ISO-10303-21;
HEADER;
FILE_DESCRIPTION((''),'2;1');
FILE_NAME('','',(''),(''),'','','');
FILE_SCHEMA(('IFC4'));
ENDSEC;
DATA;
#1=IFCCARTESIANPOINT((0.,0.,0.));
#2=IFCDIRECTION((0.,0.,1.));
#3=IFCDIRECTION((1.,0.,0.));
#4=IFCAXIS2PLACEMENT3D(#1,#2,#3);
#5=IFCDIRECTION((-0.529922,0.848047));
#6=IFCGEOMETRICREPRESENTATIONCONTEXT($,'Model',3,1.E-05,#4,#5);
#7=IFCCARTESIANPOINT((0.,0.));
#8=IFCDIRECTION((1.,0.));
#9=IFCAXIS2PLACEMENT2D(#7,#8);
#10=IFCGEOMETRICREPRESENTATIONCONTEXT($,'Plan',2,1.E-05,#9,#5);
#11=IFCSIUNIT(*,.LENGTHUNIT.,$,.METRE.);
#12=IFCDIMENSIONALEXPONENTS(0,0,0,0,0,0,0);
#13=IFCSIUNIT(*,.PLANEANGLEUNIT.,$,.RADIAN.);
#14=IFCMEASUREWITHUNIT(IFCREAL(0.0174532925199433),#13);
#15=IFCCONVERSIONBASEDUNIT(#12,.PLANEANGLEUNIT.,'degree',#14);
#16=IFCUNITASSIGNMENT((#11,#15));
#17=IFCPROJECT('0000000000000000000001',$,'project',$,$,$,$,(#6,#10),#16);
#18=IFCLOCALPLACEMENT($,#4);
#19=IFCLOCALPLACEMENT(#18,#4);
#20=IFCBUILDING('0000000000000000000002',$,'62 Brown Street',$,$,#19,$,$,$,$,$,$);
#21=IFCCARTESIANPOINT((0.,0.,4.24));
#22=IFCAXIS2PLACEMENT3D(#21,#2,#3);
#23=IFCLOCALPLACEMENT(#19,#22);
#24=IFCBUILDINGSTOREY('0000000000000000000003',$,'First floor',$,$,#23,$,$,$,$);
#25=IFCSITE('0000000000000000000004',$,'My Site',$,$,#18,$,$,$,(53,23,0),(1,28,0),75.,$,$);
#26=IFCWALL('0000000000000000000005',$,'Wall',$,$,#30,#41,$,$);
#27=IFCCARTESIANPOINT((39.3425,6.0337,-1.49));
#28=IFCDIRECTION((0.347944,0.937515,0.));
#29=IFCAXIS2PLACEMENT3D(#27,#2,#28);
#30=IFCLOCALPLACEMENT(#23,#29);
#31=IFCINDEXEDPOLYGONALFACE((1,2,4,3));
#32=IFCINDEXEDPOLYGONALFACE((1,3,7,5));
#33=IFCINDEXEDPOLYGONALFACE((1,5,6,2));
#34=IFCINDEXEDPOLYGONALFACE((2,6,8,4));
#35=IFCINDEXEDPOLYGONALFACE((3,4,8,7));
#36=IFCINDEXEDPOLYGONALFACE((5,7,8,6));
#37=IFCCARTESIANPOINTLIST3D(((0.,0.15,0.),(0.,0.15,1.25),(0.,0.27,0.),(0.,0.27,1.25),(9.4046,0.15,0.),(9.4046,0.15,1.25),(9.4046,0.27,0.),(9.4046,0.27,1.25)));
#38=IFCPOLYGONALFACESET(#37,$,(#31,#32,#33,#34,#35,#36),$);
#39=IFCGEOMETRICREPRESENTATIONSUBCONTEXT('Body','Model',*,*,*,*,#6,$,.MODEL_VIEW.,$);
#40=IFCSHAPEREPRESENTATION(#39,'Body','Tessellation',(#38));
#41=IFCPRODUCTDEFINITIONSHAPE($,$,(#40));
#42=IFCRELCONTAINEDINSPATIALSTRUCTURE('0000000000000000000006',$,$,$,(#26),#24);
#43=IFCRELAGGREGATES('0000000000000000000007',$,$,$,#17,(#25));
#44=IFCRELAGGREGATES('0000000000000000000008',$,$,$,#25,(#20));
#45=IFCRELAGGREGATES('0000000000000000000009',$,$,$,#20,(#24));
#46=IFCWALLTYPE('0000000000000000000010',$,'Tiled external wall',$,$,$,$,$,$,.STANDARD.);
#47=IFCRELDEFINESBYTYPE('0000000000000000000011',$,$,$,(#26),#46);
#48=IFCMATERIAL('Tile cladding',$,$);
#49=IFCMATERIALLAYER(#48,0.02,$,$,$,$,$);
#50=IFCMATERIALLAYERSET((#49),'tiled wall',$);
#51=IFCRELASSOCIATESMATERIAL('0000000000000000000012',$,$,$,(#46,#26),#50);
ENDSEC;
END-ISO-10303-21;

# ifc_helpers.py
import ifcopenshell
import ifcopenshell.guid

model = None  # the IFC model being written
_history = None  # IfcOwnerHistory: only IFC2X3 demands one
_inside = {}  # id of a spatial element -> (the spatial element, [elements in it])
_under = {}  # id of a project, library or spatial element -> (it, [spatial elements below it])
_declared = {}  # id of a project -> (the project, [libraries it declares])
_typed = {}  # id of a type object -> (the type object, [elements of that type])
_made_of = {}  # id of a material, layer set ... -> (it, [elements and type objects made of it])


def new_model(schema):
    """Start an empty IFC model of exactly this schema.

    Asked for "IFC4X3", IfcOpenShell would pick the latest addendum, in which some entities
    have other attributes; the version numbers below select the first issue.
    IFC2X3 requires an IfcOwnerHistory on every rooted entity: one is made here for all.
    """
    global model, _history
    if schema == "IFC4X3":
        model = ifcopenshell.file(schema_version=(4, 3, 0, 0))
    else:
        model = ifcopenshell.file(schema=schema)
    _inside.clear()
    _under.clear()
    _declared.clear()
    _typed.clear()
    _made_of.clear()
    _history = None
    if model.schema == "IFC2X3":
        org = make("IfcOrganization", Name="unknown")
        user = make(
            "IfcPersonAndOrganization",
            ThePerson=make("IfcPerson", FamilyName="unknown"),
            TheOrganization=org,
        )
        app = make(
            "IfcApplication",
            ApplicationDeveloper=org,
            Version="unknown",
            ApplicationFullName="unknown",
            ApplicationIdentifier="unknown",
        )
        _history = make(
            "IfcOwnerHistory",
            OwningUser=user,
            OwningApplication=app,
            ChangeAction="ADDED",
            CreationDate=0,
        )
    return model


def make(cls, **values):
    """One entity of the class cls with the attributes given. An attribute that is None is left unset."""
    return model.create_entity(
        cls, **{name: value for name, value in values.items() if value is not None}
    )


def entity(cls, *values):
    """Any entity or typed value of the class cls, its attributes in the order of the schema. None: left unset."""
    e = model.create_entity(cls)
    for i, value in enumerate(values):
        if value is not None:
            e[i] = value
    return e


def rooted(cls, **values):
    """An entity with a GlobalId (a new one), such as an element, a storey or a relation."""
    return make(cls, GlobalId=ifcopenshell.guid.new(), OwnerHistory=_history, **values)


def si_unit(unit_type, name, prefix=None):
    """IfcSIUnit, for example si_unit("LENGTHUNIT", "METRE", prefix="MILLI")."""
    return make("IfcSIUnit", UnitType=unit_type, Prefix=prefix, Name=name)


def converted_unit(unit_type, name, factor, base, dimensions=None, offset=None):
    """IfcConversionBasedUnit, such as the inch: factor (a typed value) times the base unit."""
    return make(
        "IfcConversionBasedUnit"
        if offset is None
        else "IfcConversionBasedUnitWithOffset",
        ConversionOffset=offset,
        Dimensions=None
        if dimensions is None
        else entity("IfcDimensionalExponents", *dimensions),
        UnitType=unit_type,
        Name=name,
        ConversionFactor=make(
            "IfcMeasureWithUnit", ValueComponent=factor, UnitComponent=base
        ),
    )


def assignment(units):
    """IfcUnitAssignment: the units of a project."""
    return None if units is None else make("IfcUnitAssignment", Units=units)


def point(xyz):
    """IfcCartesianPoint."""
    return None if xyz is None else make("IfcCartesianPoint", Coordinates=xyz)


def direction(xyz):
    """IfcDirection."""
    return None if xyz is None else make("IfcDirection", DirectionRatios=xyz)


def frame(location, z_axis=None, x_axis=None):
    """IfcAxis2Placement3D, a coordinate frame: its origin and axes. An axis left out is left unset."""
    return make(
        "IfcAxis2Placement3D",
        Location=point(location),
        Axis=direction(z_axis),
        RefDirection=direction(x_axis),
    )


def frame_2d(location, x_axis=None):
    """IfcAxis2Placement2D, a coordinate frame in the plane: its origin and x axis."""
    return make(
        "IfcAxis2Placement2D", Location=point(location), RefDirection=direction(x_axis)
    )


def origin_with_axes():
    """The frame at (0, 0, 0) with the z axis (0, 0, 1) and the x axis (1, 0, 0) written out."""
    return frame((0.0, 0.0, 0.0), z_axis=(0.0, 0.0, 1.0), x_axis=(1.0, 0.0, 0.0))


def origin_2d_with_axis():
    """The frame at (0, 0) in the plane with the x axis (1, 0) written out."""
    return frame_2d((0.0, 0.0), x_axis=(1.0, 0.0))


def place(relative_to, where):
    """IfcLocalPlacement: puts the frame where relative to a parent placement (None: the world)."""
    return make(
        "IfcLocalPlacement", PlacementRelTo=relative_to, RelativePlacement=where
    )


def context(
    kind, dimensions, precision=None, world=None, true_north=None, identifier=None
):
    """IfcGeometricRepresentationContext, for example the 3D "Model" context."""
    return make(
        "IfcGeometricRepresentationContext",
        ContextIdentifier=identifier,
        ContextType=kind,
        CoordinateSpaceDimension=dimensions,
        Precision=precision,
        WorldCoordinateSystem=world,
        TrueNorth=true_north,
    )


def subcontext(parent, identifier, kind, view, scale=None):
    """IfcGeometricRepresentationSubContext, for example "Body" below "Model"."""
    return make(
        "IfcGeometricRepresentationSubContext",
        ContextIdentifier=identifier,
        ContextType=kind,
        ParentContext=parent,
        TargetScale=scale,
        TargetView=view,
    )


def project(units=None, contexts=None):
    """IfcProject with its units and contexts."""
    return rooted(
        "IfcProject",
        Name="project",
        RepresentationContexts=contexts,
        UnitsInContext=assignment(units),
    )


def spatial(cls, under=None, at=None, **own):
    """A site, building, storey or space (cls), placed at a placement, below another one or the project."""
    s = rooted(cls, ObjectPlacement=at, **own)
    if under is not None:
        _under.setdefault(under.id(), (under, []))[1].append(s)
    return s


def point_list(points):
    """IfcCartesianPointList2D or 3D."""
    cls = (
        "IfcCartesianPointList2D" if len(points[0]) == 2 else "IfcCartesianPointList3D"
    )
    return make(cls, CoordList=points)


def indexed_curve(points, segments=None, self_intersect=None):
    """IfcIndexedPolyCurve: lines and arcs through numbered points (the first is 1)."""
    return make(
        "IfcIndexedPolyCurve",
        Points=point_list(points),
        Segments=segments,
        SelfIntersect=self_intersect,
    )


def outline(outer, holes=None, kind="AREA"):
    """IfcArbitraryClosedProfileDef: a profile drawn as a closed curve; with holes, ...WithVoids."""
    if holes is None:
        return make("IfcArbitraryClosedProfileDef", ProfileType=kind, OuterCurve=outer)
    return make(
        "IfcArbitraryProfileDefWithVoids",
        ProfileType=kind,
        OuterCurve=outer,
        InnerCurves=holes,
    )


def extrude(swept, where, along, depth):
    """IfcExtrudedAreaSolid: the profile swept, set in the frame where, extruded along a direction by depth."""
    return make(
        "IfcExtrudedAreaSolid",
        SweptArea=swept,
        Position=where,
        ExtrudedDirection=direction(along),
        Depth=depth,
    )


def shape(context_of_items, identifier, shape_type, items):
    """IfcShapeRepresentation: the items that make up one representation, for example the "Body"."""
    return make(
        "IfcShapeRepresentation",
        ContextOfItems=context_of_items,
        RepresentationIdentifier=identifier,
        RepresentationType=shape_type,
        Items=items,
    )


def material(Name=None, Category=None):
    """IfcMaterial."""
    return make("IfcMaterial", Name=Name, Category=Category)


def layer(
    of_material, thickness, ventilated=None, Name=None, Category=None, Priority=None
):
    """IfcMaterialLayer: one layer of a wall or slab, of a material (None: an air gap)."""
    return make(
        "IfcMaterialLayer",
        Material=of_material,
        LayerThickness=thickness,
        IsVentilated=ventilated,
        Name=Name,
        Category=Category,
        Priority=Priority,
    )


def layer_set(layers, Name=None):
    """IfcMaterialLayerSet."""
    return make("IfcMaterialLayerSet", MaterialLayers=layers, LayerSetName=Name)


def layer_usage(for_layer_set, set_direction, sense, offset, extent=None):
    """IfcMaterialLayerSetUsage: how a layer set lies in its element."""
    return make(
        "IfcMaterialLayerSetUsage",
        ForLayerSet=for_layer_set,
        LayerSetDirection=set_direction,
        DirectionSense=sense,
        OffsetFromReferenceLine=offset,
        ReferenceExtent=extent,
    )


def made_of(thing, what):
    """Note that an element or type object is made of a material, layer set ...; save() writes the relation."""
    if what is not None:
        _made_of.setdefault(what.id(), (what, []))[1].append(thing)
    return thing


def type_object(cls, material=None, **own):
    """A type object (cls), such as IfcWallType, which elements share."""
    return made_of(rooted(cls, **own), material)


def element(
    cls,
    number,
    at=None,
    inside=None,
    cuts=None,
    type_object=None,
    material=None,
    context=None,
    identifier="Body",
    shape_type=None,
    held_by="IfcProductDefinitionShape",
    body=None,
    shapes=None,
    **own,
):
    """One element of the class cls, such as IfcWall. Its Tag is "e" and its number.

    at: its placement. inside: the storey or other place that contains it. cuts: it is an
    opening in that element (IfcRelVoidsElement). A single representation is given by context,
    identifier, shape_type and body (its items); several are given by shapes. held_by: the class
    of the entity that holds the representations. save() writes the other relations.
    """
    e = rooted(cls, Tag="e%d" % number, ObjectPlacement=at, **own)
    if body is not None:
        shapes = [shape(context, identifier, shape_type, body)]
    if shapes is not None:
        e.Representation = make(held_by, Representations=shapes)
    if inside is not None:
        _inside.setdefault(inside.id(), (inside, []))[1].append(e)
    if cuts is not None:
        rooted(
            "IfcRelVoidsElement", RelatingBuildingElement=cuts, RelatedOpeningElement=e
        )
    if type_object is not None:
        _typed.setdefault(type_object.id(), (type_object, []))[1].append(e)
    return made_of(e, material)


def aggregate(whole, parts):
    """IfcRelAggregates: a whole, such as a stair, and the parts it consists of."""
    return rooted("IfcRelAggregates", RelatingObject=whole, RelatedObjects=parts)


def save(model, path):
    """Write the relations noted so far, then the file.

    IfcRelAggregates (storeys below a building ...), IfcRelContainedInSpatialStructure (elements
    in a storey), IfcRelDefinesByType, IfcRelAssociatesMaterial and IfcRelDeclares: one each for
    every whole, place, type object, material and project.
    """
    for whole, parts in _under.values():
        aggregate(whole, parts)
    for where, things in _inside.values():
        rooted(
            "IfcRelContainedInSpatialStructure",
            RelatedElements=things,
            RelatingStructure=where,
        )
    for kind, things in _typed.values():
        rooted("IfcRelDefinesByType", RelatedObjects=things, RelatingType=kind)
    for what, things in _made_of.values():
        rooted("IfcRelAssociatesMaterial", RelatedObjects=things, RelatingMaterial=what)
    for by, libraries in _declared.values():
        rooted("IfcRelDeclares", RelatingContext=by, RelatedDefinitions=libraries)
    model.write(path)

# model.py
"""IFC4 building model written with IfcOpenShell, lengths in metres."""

from ifc_helpers import new_model, entity, si_unit, converted_unit, direction, frame, origin_with_axes, origin_2d_with_axis, place, context, subcontext, project, spatial, indexed_curve, outline, extrude, material, layer, layer_set, layer_usage, type_object, element, save


model = new_model("IFC4")

# Units and contexts
model_context = context("Model", 3, precision=1e-05, world=origin_with_axes(), true_north=direction((-0.529922, 0.848047)))
plan_context = context("Plan", 2, precision=1e-05, world=origin_2d_with_axis(), true_north=direction((-0.529922, 0.848047)))
body_context_1 = subcontext(model_context, "Body", "Model", "MODEL_VIEW")
ifc_project = project(units=[si_unit("LENGTHUNIT", "METRE"), converted_unit("PLANEANGLEUNIT", "degree", entity("IfcReal", 0.0174532925199433), si_unit("PLANEANGLEUNIT", "RADIAN"), dimensions=[0, 0, 0, 0, 0, 0, 0])], contexts=[model_context, plan_context])

# Site, building, storey
site_placement = place(None, origin_with_axes())
site = spatial("IfcSite", under=ifc_project, at=site_placement, Name="My Site", RefLatitude=(53, 23, 0), RefLongitude=(1, 28, 0), RefElevation=75.0)
building_placement = place(site_placement, origin_with_axes())
building = spatial("IfcBuilding", under=site, at=building_placement, Name="62 Brown Street")
storey_placement = place(building_placement, frame((0.0, 0.0, 4.24), z_axis=(0.0, 0.0, 1.0), x_axis=(1.0, 0.0, 0.0)))
storey = spatial("IfcBuildingStorey", under=building, at=storey_placement, Name="First floor")

# Wall
ifc_material_1 = material(Name="Tile cladding")
ifc_layer_1 = layer(ifc_material_1, 0.02)
ifc_layer_set_1 = layer_set([ifc_layer_1], Name="tiled wall")
ifc_layer_usage_1 = layer_usage(ifc_layer_set_1, "AXIS2", "POSITIVE", 0.15)
wall_type_1 = type_object("IfcWallType", Name="Tiled external wall", PredefinedType="STANDARD", material=ifc_layer_set_1)
wall_1_placement = place(storey_placement, frame((39.3425, 6.0337, -1.49), z_axis=(0.0, 0.0, 1.0), x_axis=(0.347944, 0.937515, 0.0)))
element("IfcWall", 1, at=wall_1_placement, inside=storey, type_object=wall_type_1, material=ifc_layer_usage_1, Name="Wall", context=body_context_1, shape_type="SweptSolid", body=[
    extrude(outline(indexed_curve([(0.0, 0.0), (0.0, 0.12), (9.4046, 0.12), (9.4046, 0.0), (0.0, 0.0)], self_intersect=False)), frame((0.0, 0.15, 0.0), z_axis=(0.0, 0.0, 1.0), x_axis=(1.0, 0.0, 0.0)), (0.0, 0.0, 1.0), 1.25),
])

save(model, "model.ifc")
